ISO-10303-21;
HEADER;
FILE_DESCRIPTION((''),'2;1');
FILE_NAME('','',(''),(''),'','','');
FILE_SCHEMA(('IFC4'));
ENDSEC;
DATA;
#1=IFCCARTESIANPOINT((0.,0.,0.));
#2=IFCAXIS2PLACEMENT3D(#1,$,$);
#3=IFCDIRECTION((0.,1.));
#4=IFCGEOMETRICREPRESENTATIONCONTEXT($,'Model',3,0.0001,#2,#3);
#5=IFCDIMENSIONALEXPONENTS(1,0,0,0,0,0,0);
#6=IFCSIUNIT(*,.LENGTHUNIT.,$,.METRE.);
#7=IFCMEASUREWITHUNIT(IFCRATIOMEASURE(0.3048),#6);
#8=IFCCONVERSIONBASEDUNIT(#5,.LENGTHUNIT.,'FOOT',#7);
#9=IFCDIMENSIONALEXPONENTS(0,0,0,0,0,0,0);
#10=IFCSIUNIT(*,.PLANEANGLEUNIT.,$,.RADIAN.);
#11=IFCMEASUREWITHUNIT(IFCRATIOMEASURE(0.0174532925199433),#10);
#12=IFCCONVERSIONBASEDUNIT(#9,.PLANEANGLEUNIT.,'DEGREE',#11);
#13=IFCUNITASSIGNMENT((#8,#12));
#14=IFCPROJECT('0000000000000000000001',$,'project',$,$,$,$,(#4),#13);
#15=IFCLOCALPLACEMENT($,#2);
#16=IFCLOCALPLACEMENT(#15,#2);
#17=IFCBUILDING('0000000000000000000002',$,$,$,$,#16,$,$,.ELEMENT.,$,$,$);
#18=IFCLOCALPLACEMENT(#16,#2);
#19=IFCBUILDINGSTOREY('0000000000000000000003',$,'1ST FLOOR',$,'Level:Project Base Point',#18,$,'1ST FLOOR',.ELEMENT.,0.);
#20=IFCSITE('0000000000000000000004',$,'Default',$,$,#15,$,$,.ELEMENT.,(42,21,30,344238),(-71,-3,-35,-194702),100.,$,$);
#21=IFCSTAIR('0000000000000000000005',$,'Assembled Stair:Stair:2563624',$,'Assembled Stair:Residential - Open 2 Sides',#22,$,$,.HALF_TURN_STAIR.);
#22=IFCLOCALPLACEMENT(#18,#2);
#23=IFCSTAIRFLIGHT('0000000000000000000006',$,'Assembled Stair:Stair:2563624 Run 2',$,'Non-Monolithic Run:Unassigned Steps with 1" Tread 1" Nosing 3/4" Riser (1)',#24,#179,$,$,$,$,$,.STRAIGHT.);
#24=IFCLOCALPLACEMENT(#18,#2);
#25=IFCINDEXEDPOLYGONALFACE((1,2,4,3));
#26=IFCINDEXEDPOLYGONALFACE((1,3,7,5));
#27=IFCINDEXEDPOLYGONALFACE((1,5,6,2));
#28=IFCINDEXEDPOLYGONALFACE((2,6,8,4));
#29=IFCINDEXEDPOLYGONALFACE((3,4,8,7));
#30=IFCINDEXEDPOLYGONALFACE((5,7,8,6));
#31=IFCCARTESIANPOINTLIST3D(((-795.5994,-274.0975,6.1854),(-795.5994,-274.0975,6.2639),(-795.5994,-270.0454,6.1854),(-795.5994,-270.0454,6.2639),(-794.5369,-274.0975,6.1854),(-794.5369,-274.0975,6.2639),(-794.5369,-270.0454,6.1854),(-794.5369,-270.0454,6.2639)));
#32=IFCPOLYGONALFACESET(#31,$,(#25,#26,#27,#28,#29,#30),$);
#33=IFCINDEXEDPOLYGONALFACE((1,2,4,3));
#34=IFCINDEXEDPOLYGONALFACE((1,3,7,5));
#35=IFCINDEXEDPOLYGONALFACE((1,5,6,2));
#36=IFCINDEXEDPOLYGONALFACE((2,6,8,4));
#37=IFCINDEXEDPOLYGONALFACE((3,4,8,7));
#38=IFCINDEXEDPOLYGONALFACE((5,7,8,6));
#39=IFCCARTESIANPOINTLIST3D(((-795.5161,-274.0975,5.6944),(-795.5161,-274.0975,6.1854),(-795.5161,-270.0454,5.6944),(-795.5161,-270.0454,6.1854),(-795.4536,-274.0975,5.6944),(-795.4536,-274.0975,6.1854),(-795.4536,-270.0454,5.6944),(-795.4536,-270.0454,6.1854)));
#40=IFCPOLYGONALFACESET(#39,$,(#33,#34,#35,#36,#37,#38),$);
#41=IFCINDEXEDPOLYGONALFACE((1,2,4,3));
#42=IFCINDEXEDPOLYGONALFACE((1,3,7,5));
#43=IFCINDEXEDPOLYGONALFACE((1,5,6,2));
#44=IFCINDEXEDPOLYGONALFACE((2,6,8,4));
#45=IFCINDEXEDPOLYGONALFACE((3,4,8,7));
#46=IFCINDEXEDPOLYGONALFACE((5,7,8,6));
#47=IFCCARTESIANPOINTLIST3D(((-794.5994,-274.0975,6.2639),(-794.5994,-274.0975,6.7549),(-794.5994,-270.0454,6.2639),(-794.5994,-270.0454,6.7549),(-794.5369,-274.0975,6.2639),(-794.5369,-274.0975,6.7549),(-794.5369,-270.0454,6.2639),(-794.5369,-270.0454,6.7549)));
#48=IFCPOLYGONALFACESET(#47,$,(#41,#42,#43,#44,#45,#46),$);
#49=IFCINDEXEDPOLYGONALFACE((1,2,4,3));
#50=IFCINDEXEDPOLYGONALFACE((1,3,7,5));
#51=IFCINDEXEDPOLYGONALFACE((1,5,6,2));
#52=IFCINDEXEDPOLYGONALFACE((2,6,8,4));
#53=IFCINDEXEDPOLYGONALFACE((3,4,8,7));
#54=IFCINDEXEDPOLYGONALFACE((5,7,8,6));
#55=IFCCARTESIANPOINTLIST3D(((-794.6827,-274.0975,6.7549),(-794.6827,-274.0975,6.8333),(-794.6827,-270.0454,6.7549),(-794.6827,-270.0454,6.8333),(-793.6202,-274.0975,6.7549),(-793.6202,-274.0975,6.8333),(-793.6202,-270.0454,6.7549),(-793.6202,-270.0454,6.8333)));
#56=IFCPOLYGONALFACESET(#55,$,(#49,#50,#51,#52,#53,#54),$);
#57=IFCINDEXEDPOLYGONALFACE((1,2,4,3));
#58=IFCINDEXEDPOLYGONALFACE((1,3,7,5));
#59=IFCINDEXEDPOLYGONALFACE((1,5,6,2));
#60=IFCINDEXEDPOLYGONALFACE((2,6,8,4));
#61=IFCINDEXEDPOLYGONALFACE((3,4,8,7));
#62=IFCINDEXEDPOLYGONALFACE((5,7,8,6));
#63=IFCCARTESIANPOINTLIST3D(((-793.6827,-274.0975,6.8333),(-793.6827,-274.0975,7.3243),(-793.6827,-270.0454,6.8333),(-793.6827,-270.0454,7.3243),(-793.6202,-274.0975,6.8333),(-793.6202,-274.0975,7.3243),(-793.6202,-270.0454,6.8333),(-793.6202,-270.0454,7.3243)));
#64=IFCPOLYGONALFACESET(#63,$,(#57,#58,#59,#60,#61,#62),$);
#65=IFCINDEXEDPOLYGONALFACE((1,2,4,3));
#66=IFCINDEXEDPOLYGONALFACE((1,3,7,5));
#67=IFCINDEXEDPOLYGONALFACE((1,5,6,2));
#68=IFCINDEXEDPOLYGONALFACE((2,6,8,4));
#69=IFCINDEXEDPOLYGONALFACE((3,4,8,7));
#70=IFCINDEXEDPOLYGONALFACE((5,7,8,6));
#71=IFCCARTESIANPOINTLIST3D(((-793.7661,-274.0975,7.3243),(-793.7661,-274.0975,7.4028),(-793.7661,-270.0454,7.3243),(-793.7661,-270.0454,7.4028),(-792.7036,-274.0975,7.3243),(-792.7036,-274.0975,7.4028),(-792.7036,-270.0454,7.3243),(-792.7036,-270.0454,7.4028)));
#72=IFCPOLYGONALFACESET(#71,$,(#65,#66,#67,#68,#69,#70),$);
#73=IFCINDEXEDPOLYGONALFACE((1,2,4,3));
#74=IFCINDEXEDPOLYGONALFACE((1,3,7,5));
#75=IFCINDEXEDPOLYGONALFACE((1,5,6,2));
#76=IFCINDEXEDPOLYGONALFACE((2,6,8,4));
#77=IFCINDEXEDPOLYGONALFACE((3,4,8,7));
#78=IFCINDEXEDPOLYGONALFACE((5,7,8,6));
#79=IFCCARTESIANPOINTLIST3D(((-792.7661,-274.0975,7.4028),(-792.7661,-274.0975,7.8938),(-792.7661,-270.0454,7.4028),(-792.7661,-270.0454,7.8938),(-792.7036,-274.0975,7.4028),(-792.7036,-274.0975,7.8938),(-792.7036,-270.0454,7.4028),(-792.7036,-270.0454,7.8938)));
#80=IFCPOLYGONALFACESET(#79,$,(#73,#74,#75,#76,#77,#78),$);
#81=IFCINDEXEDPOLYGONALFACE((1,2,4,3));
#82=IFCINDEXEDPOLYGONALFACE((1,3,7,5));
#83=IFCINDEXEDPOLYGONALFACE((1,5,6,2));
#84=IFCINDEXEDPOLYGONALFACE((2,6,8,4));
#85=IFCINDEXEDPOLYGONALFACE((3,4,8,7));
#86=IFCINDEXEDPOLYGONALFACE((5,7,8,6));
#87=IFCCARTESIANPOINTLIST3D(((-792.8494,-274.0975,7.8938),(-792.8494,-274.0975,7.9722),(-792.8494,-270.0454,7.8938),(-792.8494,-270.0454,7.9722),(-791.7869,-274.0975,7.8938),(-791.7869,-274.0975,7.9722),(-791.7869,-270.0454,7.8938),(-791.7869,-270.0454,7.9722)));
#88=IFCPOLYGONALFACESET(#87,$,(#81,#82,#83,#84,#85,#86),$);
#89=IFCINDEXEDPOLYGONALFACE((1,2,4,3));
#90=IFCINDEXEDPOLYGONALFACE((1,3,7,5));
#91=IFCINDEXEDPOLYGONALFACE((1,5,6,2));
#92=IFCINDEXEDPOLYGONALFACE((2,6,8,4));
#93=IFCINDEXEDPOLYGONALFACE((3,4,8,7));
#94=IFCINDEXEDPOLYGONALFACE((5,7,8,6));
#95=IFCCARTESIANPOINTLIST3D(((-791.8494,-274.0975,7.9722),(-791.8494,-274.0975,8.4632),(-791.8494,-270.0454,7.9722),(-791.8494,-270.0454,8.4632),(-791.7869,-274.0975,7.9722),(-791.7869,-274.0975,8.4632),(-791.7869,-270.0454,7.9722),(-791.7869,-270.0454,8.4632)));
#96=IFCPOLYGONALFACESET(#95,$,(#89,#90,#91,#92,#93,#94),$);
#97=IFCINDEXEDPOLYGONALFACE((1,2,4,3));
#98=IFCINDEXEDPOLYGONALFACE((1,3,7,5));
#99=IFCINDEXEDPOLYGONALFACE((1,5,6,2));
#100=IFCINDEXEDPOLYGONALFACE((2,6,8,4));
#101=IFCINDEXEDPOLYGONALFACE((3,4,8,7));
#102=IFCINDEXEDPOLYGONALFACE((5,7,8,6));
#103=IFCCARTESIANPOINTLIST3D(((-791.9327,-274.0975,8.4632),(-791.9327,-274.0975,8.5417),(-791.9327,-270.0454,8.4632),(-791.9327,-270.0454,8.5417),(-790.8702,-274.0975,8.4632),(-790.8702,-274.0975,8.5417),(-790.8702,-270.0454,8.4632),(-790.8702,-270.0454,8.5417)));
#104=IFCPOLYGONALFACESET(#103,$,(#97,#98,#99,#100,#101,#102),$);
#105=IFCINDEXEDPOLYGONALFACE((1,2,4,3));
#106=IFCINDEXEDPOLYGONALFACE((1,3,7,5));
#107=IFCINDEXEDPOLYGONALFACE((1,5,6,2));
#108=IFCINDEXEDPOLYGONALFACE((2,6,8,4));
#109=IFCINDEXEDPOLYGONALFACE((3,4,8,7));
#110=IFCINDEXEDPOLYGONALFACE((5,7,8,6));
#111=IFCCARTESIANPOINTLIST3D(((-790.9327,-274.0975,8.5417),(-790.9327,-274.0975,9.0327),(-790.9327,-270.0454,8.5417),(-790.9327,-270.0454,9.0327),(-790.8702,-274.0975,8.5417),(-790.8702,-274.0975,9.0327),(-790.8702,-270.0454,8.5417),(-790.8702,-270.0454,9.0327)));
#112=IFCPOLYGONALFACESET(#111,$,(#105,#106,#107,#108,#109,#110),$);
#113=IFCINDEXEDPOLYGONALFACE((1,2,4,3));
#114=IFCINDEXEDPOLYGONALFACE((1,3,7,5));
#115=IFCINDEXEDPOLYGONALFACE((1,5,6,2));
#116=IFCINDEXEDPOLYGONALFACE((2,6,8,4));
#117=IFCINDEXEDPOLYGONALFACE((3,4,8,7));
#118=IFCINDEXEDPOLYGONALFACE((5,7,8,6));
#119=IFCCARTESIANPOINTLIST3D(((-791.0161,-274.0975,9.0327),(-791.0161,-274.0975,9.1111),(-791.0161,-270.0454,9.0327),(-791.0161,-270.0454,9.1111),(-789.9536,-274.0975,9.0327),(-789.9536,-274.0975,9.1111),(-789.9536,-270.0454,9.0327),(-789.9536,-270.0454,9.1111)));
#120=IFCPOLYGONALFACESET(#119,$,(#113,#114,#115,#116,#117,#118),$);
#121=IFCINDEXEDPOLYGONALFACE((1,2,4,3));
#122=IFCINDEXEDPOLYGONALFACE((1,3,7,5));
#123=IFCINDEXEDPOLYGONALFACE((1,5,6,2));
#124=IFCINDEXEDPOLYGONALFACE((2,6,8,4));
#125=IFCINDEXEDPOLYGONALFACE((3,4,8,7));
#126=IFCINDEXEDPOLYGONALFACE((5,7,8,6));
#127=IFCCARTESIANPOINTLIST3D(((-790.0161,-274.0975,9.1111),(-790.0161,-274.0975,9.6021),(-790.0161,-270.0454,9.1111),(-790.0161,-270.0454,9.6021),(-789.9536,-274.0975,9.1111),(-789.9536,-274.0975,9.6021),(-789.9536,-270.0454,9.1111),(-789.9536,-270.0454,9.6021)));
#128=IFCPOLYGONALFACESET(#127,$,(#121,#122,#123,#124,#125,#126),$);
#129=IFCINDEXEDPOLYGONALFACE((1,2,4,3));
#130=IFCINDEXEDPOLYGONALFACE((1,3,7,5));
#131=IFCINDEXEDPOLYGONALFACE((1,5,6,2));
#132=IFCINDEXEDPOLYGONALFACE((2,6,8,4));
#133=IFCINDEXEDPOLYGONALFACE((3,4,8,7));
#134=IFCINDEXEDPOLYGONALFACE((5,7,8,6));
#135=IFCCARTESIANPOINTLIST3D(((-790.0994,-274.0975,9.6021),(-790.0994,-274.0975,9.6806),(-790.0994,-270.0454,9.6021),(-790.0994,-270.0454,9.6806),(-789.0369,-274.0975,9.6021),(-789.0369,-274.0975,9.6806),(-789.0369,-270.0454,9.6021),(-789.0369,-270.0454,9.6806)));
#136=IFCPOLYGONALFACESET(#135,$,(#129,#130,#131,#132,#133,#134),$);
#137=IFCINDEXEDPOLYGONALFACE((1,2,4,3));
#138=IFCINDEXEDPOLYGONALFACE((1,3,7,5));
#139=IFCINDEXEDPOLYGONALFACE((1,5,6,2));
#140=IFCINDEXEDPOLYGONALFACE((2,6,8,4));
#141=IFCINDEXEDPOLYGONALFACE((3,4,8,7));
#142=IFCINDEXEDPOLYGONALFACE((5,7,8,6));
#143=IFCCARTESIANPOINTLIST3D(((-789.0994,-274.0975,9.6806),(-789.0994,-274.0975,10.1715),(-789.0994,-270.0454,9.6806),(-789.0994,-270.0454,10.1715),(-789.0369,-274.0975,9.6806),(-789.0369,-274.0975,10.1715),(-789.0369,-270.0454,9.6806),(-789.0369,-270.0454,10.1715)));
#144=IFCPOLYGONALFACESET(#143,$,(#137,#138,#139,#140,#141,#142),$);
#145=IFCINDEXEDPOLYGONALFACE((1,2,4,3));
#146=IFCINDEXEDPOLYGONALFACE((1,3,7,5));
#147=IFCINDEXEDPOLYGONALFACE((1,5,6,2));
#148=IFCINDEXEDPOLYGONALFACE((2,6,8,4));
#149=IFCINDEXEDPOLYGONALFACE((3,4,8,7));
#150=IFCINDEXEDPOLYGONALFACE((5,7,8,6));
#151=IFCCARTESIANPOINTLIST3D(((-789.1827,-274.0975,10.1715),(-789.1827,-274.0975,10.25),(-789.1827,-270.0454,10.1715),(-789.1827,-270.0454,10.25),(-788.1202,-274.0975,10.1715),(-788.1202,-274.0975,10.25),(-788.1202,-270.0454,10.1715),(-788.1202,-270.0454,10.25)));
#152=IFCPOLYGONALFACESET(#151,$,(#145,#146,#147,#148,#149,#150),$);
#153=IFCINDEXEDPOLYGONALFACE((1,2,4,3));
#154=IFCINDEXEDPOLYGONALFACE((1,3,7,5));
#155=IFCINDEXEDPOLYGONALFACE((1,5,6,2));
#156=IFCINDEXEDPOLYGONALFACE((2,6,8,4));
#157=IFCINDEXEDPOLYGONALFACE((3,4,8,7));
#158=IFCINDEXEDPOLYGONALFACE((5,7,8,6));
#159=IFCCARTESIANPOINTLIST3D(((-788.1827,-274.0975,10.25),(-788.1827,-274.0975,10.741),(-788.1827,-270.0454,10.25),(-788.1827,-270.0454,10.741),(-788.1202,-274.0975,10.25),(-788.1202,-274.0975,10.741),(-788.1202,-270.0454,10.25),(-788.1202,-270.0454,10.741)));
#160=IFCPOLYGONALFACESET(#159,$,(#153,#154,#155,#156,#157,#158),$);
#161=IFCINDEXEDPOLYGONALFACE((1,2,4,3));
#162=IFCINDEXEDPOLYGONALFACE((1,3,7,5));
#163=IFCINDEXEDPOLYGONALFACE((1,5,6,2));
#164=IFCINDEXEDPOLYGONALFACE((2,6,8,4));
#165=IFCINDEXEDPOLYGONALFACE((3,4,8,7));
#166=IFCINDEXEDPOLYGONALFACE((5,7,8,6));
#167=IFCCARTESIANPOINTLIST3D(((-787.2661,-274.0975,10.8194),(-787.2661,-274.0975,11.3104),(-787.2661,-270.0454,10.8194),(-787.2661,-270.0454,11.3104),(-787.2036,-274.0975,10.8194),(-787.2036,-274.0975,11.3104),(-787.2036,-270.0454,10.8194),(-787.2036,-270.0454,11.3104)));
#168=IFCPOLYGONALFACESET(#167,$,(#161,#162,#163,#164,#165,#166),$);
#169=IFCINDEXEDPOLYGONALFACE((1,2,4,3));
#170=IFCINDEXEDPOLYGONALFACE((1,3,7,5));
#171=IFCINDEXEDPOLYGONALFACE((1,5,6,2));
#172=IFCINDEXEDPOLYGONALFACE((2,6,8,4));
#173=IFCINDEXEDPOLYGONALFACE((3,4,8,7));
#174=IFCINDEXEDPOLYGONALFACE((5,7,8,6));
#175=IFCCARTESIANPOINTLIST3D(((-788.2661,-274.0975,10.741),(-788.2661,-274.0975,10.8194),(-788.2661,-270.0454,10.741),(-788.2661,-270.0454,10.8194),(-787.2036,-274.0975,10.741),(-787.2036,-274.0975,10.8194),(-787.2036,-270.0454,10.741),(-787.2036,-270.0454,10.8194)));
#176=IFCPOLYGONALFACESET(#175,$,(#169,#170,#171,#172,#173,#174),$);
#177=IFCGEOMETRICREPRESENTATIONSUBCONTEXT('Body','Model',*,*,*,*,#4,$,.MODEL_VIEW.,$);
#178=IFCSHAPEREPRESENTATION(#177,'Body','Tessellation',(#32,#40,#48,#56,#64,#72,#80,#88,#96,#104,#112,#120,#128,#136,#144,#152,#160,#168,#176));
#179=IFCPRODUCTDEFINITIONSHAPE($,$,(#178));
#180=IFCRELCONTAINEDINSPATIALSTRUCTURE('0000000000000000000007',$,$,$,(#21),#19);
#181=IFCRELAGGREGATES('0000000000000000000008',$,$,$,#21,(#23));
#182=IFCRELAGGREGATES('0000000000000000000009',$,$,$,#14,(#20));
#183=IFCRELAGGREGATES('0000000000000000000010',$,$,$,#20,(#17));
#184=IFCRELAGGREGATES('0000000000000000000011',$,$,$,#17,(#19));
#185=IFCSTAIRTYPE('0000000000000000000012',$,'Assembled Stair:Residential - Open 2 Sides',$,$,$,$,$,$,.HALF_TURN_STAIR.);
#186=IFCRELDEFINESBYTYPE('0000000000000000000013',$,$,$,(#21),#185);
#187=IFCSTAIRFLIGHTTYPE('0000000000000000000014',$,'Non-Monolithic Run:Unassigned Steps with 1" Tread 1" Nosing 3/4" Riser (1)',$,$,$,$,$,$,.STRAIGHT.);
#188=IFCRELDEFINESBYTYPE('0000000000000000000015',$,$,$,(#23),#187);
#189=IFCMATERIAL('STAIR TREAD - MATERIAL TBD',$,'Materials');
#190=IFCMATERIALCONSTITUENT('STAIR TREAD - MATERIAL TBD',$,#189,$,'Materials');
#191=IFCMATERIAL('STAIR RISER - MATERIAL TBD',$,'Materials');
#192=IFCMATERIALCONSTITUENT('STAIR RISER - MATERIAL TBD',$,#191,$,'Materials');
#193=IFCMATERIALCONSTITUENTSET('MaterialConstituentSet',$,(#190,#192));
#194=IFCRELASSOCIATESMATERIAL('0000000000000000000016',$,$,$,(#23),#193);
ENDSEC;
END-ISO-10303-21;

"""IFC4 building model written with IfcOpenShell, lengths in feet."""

from ifc_helpers import new_model, entity, si_unit, converted_unit, direction, frame, frame_2d, origin, origin_2d_with_axis, place, context, subcontext, project, spatial, rectangle, extrude, material, constituent, constituent_set, type_object, element, aggregate, save


model = new_model("IFC4")

# Units and contexts
model_context = context("Model", 3, precision=0.0001, world=origin(), true_north=direction((0.0, 1.0)))
body_context = subcontext(model_context, "Body", "Model", "MODEL_VIEW")
ifc_project = project(units=[converted_unit("LENGTHUNIT", "FOOT", entity("IfcRatioMeasure", 0.3048), si_unit("LENGTHUNIT", "METRE"), dimensions=[1, 0, 0, 0, 0, 0, 0]), converted_unit("PLANEANGLEUNIT", "DEGREE", entity("IfcRatioMeasure", 0.0174532925199433), si_unit("PLANEANGLEUNIT", "RADIAN"), dimensions=[0, 0, 0, 0, 0, 0, 0])], contexts=[model_context])

# Site, building, storey
site_placement = place(None, origin())
site = spatial("IfcSite", under=ifc_project, at=site_placement, Name="Default", CompositionType="ELEMENT", RefLatitude=(42, 21, 30, 344238), RefLongitude=(-71, -3, -35, -194702), RefElevation=100.0)
building_placement = place(site_placement, origin())
building = spatial("IfcBuilding", under=site, at=building_placement, CompositionType="ELEMENT")
storey_placement = place(building_placement, origin())
storey = spatial("IfcBuildingStorey", under=building, at=storey_placement, Name="1ST FLOOR", ObjectType="Level:Project Base Point", LongName="1ST FLOOR", CompositionType="ELEMENT", Elevation=0.0)

# Stair
stair_type = type_object("IfcStairType", Name="Assembled Stair:Residential - Open 2 Sides", PredefinedType="HALF_TURN_STAIR")
stair_placement = place(storey_placement, origin())
stair = element("IfcStair", 1, at=stair_placement, inside=storey, type_object=stair_type, Name="Assembled Stair:Stair:2563624", ObjectType="Assembled Stair:Residential - Open 2 Sides", PredefinedType="HALF_TURN_STAIR")

# Shared definitions
ifc_material_1 = material(Name="STAIR TREAD - MATERIAL TBD", Category="Materials")

# Stair flight
ifc_constituent_1 = constituent(ifc_material_1, Name="STAIR TREAD - MATERIAL TBD", Category="Materials")
ifc_material_2 = material(Name="STAIR RISER - MATERIAL TBD", Category="Materials")
ifc_constituent_2 = constituent(ifc_material_2, Name="STAIR RISER - MATERIAL TBD", Category="Materials")
ifc_constituent_set = constituent_set(constituents=[ifc_constituent_1, ifc_constituent_2], Name="MaterialConstituentSet")
stair_flight_type = type_object("IfcStairFlightType", Name="Non-Monolithic Run:Unassigned Steps with 1\" Tread 1\" Nosing 3/4\" Riser (1)", PredefinedType="STRAIGHT")
stair_flight_placement = place(stair_placement, frame((-795.5994, -274.0975, 0.0)))
stair_flight = element("IfcStairFlight", 2, at=stair_flight_placement, type_object=stair_flight_type, material=ifc_constituent_set, Name="Assembled Stair:Stair:2563624 Run 2", ObjectType="Non-Monolithic Run:Unassigned Steps with 1\" Tread 1\" Nosing 3/4\" Riser (1)", PredefinedType="STRAIGHT", context=body_context, shape_type="SweptSolid", body=[
    extrude(rectangle(XDim=1.0625, YDim=4.0521, at=frame_2d((0.0, 0.0), x_axis=(1.0, 0.0))), frame((0.5312, 2.026, 6.1854), z_axis=(0.0, 0.0, 1.0), x_axis=(-1.0, 0.0, 0.0)), (0.0, 0.0, 1.0), 0.0785),
    extrude(rectangle(XDim=4.0521, YDim=0.0625, at=origin_2d_with_axis()), frame((0.1146, 2.026, 5.6944), z_axis=(0.0, 0.0, 1.0), x_axis=(0.0, 1.0, 0.0)), (0.0, 0.0, 1.0), 0.491),
    extrude(rectangle(XDim=4.0521, YDim=0.0625, at=frame_2d((0.0, 0.0), x_axis=(1.0, 0.0))), frame((1.0312, 2.026, 6.2639), z_axis=(0.0, 0.0, 1.0), x_axis=(0.0, 1.0, 0.0)), (0.0, 0.0, 1.0), 0.491),
    extrude(rectangle(XDim=1.0625, YDim=4.0521, at=frame_2d((0.0, 0.0), x_axis=(1.0, 0.0))), frame((1.4479, 2.026, 6.7549), z_axis=(0.0, 0.0, 1.0), x_axis=(-1.0, 0.0, 0.0)), (0.0, 0.0, 1.0), 0.0785),
    extrude(rectangle(XDim=4.0521, YDim=0.0625, at=frame_2d((0.0, 0.0), x_axis=(1.0, 0.0))), frame((1.9479, 2.026, 6.8333), z_axis=(0.0, 0.0, 1.0), x_axis=(0.0, 1.0, 0.0)), (0.0, 0.0, 1.0), 0.491),
    extrude(rectangle(XDim=1.0625, YDim=4.0521, at=frame_2d((0.0, 0.0), x_axis=(1.0, 0.0))), frame((2.3646, 2.026, 7.3243), z_axis=(0.0, 0.0, 1.0), x_axis=(-1.0, 0.0, 0.0)), (0.0, 0.0, 1.0), 0.0785),
    extrude(rectangle(XDim=4.0521, YDim=0.0625, at=origin_2d_with_axis()), frame((2.8646, 2.026, 7.4028), z_axis=(0.0, 0.0, 1.0), x_axis=(0.0, 1.0, 0.0)), (0.0, 0.0, 1.0), 0.491),
    extrude(rectangle(XDim=1.0625, YDim=4.0521, at=frame_2d((0.0, 0.0), x_axis=(1.0, 0.0))), frame((3.2812, 2.026, 7.8938), z_axis=(0.0, 0.0, 1.0), x_axis=(-1.0, 0.0, 0.0)), (0.0, 0.0, 1.0), 0.0785),
    extrude(rectangle(XDim=4.0521, YDim=0.0625, at=frame_2d((0.0, 0.0), x_axis=(1.0, 0.0))), frame((3.7812, 2.026, 7.9722), z_axis=(0.0, 0.0, 1.0), x_axis=(0.0, 1.0, 0.0)), (0.0, 0.0, 1.0), 0.491),
    extrude(rectangle(XDim=1.0625, YDim=4.0521, at=frame_2d((0.0, 0.0), x_axis=(1.0, 0.0))), frame((4.1979, 2.026, 8.4632), z_axis=(0.0, 0.0, 1.0), x_axis=(-1.0, 0.0, 0.0)), (0.0, 0.0, 1.0), 0.0785),
    extrude(rectangle(XDim=4.0521, YDim=0.0625, at=frame_2d((0.0, 0.0), x_axis=(1.0, 0.0))), frame((4.6979, 2.026, 8.5417), z_axis=(0.0, 0.0, 1.0), x_axis=(0.0, 1.0, 0.0)), (0.0, 0.0, 1.0), 0.491),
    extrude(rectangle(XDim=1.0625, YDim=4.0521, at=frame_2d((0.0, 0.0), x_axis=(1.0, 0.0))), frame((5.1146, 2.026, 9.0327), z_axis=(0.0, 0.0, 1.0), x_axis=(-1.0, 0.0, 0.0)), (0.0, 0.0, 1.0), 0.0785),
    extrude(rectangle(XDim=4.0521, YDim=0.0625, at=origin_2d_with_axis()), frame((5.6146, 2.026, 9.1111), z_axis=(0.0, 0.0, 1.0), x_axis=(0.0, 1.0, 0.0)), (0.0, 0.0, 1.0), 0.491),
    extrude(rectangle(XDim=1.0625, YDim=4.0521, at=frame_2d((0.0, 0.0), x_axis=(1.0, 0.0))), frame((6.0312, 2.026, 9.6021), z_axis=(0.0, 0.0, 1.0), x_axis=(-1.0, 0.0, 0.0)), (0.0, 0.0, 1.0), 0.0785),
    extrude(rectangle(XDim=4.0521, YDim=0.0625, at=origin_2d_with_axis()), frame((6.5312, 2.026, 9.6806), z_axis=(0.0, 0.0, 1.0), x_axis=(0.0, 1.0, 0.0)), (0.0, 0.0, 1.0), 0.491),
    extrude(rectangle(XDim=1.0625, YDim=4.0521, at=frame_2d((0.0, 0.0), x_axis=(1.0, 0.0))), frame((6.9479, 2.026, 10.1715), z_axis=(0.0, 0.0, 1.0), x_axis=(-1.0, 0.0, 0.0)), (0.0, 0.0, 1.0), 0.0785),
    extrude(rectangle(XDim=4.0521, YDim=0.0625, at=origin_2d_with_axis()), frame((7.4479, 2.026, 10.25), z_axis=(0.0, 0.0, 1.0), x_axis=(0.0, 1.0, 0.0)), (0.0, 0.0, 1.0), 0.491),
    extrude(rectangle(XDim=4.0521, YDim=0.0625, at=origin_2d_with_axis()), frame((8.3646, 2.026, 10.8194), z_axis=(0.0, 0.0, 1.0), x_axis=(0.0, 1.0, 0.0)), (0.0, 0.0, 1.0), 0.491),
    extrude(rectangle(XDim=1.0625, YDim=4.0521, at=frame_2d((0.0, 0.0), x_axis=(1.0, 0.0))), frame((7.8646, 2.026, 10.741), z_axis=(0.0, 0.0, 1.0), x_axis=(-1.0, 0.0, 0.0)), (0.0, 0.0, 1.0), 0.0785),
])
aggregate(stair, [stair_flight])

save(model, "model.ifc")
